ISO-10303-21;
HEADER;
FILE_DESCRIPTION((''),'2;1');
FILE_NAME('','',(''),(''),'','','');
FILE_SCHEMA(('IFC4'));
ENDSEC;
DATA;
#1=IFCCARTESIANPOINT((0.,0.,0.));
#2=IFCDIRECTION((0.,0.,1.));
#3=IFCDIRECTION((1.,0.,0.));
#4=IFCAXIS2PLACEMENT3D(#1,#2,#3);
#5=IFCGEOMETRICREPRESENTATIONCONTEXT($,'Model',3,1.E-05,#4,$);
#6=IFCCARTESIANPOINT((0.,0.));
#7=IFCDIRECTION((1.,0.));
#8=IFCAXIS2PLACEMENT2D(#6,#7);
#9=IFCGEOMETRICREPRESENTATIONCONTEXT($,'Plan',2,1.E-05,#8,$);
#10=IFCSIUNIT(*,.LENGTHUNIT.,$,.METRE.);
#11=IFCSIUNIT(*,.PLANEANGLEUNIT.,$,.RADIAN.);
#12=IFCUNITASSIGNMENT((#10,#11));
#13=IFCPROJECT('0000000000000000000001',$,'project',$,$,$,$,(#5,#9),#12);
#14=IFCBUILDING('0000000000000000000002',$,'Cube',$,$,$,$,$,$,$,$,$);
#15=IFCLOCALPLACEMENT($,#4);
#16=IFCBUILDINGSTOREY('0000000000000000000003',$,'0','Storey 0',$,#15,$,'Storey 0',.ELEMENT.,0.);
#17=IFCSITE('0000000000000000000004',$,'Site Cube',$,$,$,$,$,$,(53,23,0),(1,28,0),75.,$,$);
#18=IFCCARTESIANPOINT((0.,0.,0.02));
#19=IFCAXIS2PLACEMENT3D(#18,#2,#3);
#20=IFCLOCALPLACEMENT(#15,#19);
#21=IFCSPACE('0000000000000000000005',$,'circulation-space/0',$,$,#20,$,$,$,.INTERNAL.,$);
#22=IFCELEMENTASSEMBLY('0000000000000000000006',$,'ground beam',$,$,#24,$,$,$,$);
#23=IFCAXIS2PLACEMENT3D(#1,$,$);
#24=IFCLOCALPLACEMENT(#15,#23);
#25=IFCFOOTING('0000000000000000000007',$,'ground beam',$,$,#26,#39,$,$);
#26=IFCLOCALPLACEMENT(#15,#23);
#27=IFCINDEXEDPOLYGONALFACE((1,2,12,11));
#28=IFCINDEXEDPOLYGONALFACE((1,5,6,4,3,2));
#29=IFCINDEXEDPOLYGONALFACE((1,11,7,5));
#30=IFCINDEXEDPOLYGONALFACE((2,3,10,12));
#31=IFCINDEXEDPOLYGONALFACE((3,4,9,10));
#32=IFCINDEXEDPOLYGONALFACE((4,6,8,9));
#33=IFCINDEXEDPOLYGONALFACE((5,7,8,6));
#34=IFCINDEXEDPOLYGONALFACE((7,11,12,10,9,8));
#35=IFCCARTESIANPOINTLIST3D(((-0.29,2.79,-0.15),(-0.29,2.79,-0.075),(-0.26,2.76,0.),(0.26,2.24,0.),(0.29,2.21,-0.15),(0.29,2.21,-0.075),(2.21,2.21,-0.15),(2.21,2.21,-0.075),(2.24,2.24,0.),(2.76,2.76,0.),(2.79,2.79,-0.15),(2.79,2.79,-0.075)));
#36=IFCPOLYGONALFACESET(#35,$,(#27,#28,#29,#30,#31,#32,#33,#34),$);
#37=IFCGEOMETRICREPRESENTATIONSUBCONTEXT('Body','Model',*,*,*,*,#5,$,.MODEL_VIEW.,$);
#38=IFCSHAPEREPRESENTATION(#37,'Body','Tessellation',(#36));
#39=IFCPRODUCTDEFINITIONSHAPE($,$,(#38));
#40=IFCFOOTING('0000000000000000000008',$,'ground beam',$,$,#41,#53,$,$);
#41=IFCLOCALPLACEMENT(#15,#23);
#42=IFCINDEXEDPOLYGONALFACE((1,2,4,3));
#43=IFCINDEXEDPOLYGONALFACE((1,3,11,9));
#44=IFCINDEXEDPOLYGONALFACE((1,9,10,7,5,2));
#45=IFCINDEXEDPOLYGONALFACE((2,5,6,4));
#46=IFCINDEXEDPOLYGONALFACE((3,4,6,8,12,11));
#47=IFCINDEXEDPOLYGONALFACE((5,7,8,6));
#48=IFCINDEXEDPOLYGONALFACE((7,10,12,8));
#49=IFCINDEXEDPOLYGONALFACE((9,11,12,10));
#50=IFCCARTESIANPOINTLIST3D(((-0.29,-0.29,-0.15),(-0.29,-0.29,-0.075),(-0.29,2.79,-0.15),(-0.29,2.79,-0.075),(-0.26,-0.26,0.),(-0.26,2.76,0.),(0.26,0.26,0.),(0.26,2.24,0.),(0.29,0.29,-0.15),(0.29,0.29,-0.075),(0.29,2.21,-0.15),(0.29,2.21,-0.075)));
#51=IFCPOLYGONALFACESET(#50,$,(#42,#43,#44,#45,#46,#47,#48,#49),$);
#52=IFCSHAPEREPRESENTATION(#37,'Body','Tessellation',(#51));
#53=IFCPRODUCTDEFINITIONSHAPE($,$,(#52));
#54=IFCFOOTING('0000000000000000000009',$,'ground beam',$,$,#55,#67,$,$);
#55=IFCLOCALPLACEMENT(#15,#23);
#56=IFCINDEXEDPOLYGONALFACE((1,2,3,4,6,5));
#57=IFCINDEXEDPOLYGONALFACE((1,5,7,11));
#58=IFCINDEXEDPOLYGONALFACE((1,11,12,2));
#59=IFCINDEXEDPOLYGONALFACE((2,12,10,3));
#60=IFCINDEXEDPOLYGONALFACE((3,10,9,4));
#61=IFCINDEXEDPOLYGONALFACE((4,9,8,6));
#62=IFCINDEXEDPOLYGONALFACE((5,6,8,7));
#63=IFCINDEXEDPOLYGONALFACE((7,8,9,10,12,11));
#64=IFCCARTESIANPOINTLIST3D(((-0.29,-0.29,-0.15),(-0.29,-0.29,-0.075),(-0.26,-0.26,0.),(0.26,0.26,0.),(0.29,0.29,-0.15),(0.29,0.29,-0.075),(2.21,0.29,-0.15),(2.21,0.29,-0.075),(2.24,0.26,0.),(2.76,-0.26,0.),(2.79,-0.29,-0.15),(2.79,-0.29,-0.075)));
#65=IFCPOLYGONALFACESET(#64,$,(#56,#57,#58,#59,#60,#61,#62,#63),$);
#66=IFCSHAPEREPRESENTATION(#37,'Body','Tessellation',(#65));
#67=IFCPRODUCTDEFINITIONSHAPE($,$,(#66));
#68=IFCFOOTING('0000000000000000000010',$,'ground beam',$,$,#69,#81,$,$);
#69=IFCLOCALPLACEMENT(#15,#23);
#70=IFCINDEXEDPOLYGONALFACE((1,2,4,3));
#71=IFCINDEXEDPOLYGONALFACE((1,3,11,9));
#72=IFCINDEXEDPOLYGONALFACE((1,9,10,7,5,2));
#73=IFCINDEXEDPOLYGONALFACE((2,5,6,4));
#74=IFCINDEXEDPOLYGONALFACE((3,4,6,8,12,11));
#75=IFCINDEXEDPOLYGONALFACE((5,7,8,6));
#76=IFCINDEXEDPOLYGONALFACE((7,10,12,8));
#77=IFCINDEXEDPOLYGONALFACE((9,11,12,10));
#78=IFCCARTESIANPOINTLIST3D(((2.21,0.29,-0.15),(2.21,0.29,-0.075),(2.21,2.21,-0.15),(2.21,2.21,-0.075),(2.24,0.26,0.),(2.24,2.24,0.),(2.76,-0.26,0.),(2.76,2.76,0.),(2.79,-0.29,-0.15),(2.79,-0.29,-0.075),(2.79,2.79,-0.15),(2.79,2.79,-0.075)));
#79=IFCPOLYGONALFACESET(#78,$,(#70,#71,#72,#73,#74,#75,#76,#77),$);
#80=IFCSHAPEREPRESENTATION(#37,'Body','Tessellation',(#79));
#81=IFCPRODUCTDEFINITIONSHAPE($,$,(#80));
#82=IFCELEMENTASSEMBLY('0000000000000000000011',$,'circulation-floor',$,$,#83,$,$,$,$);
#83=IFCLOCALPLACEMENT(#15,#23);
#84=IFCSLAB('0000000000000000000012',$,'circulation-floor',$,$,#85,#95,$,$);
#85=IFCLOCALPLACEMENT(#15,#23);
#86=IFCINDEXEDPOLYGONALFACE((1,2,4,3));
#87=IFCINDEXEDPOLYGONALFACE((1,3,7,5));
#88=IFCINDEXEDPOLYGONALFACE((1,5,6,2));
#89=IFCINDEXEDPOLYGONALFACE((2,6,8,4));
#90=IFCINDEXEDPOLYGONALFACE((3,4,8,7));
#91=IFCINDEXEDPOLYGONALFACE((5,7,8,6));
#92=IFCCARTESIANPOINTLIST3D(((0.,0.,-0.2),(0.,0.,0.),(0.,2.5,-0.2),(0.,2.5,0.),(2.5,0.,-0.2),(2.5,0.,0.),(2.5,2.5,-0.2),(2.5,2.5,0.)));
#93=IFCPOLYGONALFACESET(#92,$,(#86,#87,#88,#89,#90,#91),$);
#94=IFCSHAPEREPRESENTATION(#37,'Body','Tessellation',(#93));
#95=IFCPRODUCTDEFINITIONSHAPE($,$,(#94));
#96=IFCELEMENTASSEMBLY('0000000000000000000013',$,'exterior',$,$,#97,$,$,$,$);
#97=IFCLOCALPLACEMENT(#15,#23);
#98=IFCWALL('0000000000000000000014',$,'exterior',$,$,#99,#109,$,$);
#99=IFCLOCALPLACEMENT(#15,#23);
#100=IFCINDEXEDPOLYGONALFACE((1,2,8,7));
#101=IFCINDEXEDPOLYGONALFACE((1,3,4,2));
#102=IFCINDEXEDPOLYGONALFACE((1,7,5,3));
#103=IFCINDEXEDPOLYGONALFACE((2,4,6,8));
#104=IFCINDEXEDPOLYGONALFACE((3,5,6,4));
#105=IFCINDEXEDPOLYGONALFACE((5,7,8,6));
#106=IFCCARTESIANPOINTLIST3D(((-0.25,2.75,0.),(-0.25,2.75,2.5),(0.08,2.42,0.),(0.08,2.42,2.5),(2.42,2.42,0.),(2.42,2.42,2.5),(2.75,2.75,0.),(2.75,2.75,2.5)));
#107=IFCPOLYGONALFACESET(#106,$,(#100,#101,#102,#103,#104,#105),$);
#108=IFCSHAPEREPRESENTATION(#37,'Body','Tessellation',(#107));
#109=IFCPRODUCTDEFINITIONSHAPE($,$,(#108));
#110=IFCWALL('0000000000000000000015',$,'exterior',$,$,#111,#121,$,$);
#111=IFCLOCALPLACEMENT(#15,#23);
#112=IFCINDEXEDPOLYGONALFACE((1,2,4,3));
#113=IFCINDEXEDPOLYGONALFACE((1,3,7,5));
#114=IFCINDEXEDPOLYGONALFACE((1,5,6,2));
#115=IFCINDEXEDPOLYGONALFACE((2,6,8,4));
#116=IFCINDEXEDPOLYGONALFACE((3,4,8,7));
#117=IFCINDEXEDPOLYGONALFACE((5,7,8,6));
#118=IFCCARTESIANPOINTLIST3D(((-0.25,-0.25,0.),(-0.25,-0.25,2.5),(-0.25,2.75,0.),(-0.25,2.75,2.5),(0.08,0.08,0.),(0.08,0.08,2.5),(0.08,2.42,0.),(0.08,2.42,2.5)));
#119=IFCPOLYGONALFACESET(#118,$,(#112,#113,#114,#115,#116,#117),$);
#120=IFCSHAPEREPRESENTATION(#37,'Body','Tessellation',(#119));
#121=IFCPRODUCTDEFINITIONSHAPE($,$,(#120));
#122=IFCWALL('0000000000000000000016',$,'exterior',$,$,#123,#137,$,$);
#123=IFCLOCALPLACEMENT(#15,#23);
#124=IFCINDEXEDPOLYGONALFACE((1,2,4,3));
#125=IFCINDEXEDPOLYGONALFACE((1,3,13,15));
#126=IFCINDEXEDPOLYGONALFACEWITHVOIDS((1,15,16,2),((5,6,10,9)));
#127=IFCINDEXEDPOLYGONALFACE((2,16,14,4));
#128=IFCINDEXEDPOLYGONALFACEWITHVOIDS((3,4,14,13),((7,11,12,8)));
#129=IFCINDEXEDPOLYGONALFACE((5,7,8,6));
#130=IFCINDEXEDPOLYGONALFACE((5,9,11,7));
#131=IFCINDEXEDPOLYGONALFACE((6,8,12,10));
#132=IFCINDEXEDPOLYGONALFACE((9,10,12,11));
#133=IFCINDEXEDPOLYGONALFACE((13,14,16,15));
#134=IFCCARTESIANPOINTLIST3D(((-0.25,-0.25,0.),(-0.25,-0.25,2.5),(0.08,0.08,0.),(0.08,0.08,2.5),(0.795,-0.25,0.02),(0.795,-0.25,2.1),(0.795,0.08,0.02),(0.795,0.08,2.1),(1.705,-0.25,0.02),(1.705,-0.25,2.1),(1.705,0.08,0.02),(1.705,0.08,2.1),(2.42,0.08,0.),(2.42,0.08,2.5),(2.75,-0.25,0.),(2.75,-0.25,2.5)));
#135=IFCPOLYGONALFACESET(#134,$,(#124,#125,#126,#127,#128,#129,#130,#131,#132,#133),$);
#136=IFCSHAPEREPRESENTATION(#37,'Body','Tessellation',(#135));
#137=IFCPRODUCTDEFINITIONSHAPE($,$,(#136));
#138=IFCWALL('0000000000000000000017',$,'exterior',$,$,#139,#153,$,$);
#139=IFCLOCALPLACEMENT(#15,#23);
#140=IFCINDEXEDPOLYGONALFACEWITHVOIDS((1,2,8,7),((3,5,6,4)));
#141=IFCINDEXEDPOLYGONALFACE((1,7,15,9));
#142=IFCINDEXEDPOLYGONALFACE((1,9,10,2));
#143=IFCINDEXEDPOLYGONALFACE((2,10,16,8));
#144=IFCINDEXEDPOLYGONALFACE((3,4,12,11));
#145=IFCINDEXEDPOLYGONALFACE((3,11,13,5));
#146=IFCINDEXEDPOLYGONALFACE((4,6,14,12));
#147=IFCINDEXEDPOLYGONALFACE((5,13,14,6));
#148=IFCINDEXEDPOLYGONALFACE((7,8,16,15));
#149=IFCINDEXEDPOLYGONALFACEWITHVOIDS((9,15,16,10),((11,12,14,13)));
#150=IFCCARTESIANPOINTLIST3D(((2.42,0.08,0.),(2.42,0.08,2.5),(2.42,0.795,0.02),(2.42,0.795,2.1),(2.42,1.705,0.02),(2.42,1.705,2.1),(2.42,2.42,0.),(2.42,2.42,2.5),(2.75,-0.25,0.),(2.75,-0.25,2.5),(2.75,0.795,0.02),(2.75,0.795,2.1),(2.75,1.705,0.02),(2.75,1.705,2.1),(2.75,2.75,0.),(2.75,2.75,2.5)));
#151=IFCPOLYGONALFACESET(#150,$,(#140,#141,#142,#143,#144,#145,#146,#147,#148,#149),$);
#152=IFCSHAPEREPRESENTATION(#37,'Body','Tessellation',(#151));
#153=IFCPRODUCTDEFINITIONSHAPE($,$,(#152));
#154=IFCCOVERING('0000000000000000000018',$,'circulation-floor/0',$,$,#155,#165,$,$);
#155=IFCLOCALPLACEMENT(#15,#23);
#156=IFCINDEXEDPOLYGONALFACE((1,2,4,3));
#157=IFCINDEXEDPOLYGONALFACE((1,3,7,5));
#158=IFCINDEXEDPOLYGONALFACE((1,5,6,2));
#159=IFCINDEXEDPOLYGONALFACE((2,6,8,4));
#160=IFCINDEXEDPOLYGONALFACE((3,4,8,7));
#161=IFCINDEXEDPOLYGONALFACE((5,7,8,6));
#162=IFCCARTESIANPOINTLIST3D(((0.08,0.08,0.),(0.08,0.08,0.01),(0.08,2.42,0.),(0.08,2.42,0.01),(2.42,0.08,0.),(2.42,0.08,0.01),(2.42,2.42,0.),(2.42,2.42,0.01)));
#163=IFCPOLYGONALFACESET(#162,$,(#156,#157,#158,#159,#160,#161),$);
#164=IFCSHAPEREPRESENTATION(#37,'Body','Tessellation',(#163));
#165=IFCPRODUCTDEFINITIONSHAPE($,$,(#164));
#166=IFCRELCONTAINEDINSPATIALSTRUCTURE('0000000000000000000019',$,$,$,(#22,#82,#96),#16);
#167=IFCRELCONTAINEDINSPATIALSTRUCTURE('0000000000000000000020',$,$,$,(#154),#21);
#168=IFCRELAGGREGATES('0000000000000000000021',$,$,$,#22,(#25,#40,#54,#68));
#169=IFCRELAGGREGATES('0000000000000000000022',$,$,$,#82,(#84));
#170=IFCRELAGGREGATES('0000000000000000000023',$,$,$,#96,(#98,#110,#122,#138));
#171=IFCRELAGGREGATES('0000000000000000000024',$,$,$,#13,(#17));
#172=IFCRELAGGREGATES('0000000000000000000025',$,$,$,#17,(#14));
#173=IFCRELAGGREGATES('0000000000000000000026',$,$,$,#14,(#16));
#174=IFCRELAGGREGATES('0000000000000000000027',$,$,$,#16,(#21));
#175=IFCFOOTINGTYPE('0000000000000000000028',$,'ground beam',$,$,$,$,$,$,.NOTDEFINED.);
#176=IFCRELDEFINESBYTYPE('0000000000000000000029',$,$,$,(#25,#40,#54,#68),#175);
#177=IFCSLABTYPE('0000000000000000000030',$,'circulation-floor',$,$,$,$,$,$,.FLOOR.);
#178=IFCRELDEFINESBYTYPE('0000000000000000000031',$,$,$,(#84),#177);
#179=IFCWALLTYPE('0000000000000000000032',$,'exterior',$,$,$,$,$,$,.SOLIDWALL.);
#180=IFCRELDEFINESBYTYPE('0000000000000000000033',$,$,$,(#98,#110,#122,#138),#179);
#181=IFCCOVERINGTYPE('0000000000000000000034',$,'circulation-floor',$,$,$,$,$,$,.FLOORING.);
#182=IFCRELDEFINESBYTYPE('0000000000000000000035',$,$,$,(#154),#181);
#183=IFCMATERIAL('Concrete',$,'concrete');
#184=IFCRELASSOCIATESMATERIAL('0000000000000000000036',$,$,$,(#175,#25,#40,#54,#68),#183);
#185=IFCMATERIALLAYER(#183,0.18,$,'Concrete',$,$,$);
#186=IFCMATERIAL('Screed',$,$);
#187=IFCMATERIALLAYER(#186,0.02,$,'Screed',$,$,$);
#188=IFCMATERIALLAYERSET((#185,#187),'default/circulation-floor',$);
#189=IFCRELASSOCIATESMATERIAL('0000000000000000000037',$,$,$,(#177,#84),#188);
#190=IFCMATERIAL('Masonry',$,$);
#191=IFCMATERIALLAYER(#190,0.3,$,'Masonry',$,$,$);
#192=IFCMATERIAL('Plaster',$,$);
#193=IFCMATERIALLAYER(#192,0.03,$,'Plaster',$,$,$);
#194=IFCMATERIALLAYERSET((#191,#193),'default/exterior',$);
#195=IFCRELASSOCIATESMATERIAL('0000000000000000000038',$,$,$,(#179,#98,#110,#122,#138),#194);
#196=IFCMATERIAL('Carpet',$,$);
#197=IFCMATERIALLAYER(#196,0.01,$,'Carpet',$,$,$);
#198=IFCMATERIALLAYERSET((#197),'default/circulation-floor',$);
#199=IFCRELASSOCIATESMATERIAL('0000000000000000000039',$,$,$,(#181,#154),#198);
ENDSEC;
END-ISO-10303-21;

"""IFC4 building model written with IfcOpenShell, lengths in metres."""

from ifc_helpers import new_model, si_unit, frame, origin, origin_with_axes, origin_2d_with_axis, place, context, subcontext, project, spatial, polyline, outline, extrude, clip, halfspace, material, layer, layer_set, layer_usage, material_profile, profile_set, profile_usage, type_object, element, aggregate, save


model = new_model("IFC4")

# Units and contexts
model_context = context("Model", 3, precision=1e-05, world=origin_with_axes())
plan_context = context("Plan", 2, precision=1e-05, world=origin_2d_with_axis())
body_context = subcontext(model_context, "Body", "Model", "MODEL_VIEW")
ifc_project = project(units=[si_unit("LENGTHUNIT", "METRE"), si_unit("PLANEANGLEUNIT", "RADIAN")], contexts=[model_context, plan_context])

# Site, building, storey
site = spatial("IfcSite", under=ifc_project, Name="Site Cube", RefLatitude=(53, 23, 0), RefLongitude=(1, 28, 0), RefElevation=75.0)
building = spatial("IfcBuilding", under=site, Name="Cube")
storey_placement = place(None, origin_with_axes())
storey = spatial("IfcBuildingStorey", under=building, at=storey_placement, Name="0", Description="Storey 0", LongName="Storey 0", CompositionType="ELEMENT", Elevation=0.0)

# Element assembly, footings
assembly_1_placement = place(storey_placement, origin_with_axes())
assembly_1 = element("IfcElementAssembly", 1, at=assembly_1_placement, inside=storey, Name="ground beam")
ifc_material_1 = material(Name="Concrete", Category="concrete")
ifc_material_profile = material_profile(ifc_material_1, outline(polyline([(-0.26, 0.0), (-0.29, -0.075), (-0.29, -0.15), (0.29, -0.15), (0.29, -0.075), (0.26, 0.0), (-0.26, 0.0)])))
ifc_profile_set = profile_set([ifc_material_profile])
ifc_profile_usage_1 = profile_usage(ifc_profile_set)
footing_type = type_object("IfcFootingType", Name="ground beam", PredefinedType="NOTDEFINED", material=ifc_profile_set)
footing_1_placement = place(assembly_1_placement, frame((-1.0, 2.5, 0.0), z_axis=(1.0, 0.0, 0.0), x_axis=(0.0, 1.0, 0.0)))
footing_1 = element("IfcFooting", 2, at=footing_1_placement, type_object=footing_type, material=ifc_profile_usage_1, Name="ground beam", context=body_context, shape_type="Clipping", body=[
    clip(clip(extrude(outline(polyline([(-0.26, 0.0), (-0.29, -0.075), (-0.29, -0.15), (0.29, -0.15), (0.29, -0.075), (0.26, 0.0), (-0.26, 0.0)])), origin_with_axes(), (0.0, 0.0, 1.0), 4.5), halfspace(frame((0.0, 0.0, 1.0), z_axis=(-0.707107, 0.0, -0.707107), x_axis=(0.707107, 0.0, -0.707107)), False)), halfspace(frame((0.0, 0.0, 3.5), z_axis=(-0.707107, 0.0, 0.707107), x_axis=(0.707107, 0.0, 0.707107)), False)),
])
ifc_profile_usage_2 = profile_usage(ifc_profile_set)
footing_2_placement = place(assembly_1_placement, frame((0.0, -1.0, 0.0), z_axis=(0.0, 1.0, 0.0), x_axis=(-1.0, 0.0, 0.0)))
footing_2 = element("IfcFooting", 3, at=footing_2_placement, type_object=footing_type, material=ifc_profile_usage_2, Name="ground beam", context=body_context, shape_type="Clipping", body=[
    clip(clip(extrude(outline(polyline([(-0.26, 0.0), (-0.29, -0.075), (-0.29, -0.15), (0.29, -0.15), (0.29, -0.075), (0.26, 0.0), (-0.26, 0.0)])), origin_with_axes(), (0.0, 0.0, 1.0), 4.5), halfspace(frame((0.0, 0.0, 1.0), z_axis=(-0.707107, 0.0, -0.707107), x_axis=(0.707107, 0.0, -0.707107)), False)), halfspace(frame((0.0, 0.0, 3.5), z_axis=(-0.707107, 0.0, 0.707107), x_axis=(0.707107, 0.0, 0.707107)), False)),
])
ifc_profile_usage_3 = profile_usage(ifc_profile_set)
footing_3_placement = place(assembly_1_placement, frame((3.5, 0.0, 0.0), z_axis=(-1.0, 0.0, 0.0), x_axis=(0.0, -1.0, 0.0)))
footing_3 = element("IfcFooting", 4, at=footing_3_placement, type_object=footing_type, material=ifc_profile_usage_3, Name="ground beam", context=body_context, shape_type="Clipping", body=[
    clip(clip(extrude(outline(polyline([(-0.26, 0.0), (-0.29, -0.075), (-0.29, -0.15), (0.29, -0.15), (0.29, -0.075), (0.26, 0.0), (-0.26, 0.0)])), origin_with_axes(), (0.0, 0.0, 1.0), 4.5), halfspace(frame((0.0, 0.0, 1.0), z_axis=(-0.707107, 0.0, -0.707107), x_axis=(0.707107, 0.0, -0.707107)), False)), halfspace(frame((0.0, 0.0, 3.5), z_axis=(-0.707107, 0.0, 0.707107), x_axis=(0.707107, 0.0, 0.707107)), False)),
])
ifc_profile_usage_4 = profile_usage(ifc_profile_set)
footing_4_placement = place(assembly_1_placement, frame((2.5, 3.5, 0.0), z_axis=(0.0, -1.0, 0.0), x_axis=(1.0, 0.0, 0.0)))
footing_4 = element("IfcFooting", 5, at=footing_4_placement, type_object=footing_type, material=ifc_profile_usage_4, Name="ground beam", context=body_context, shape_type="Clipping", body=[
    clip(clip(extrude(outline(polyline([(-0.26, 0.0), (-0.29, -0.075), (-0.29, -0.15), (0.29, -0.15), (0.29, -0.075), (0.26, 0.0), (-0.26, 0.0)])), origin_with_axes(), (0.0, 0.0, 1.0), 4.5), halfspace(frame((0.0, 0.0, 1.0), z_axis=(-0.707107, 0.0, -0.707107), x_axis=(0.707107, 0.0, -0.707107)), False)), halfspace(frame((0.0, 0.0, 3.5), z_axis=(-0.707107, 0.0, 0.707107), x_axis=(0.707107, 0.0, 0.707107)), False)),
])
aggregate(assembly_1, [footing_1, footing_2, footing_3, footing_4])

# Element assembly, slab
assembly_2_placement = place(storey_placement, origin_with_axes())
assembly_2 = element("IfcElementAssembly", 6, at=assembly_2_placement, inside=storey, Name="circulation-floor")
ifc_layer_1 = layer(ifc_material_1, 0.18, Name="Concrete")
ifc_material_2 = material(Name="Screed")
ifc_layer_2 = layer(ifc_material_2, 0.02, Name="Screed")
ifc_layer_set_1 = layer_set([ifc_layer_1, ifc_layer_2], Name="default/circulation-floor")
ifc_layer_usage_1 = layer_usage(ifc_layer_set_1, "AXIS3", "POSITIVE", 0.0)
slab_type = type_object("IfcSlabType", Name="circulation-floor", PredefinedType="FLOOR", material=ifc_layer_set_1)
slab_placement = place(assembly_2_placement, frame((0.0, 2.5, -0.2), z_axis=(0.0, 0.0, -1.0), x_axis=(0.0, 1.0, 0.0)))
slab = element("IfcSlab", 7, at=slab_placement, type_object=slab_type, material=ifc_layer_usage_1, Name="circulation-floor", context=body_context, shape_type="SweptSolid", body=[
    extrude(outline(polyline([(0.0, 0.0), (0.0, 2.5), (-2.5, 2.5), (-2.5, 0.0), (0.0, 0.0)])), origin(), (0.0, 0.0, -1.0), 0.2),
])
aggregate(assembly_2, [slab])

# Element assembly, walls, openings
assembly_3_placement = place(storey_placement, frame((2.5, 2.5, 0.0), z_axis=(0.0, 0.0, 1.0), x_axis=(-1.0, 0.0, 0.0)))
assembly_3 = element("IfcElementAssembly", 8, at=assembly_3_placement, inside=storey, Name="exterior")
ifc_material_3 = material(Name="Masonry")
ifc_layer_3 = layer(ifc_material_3, 0.3, Name="Masonry")
ifc_material_4 = material(Name="Plaster")
ifc_layer_4 = layer(ifc_material_4, 0.03, Name="Plaster")
ifc_layer_set_2 = layer_set([ifc_layer_3, ifc_layer_4], Name="default/exterior")
ifc_layer_usage_2 = layer_usage(ifc_layer_set_2, "AXIS2", "POSITIVE", -0.25)
wall_type = type_object("IfcWallType", Name="exterior", PredefinedType="SOLIDWALL", material=ifc_layer_set_2)
wall_1_placement = place(assembly_3_placement, origin_with_axes())
wall_1 = element("IfcWall", 9, at=wall_1_placement, type_object=wall_type, material=ifc_layer_usage_2, Name="exterior", context=body_context, shape_type="SweptSolid", body=[
    extrude(outline(polyline([(0.08, 0.08), (-0.25, -0.25), (2.75, -0.25), (2.42, 0.08), (0.08, 0.08)])), origin(), (0.0, 0.0, 1.0), 2.5),
])
ifc_layer_usage_3 = layer_usage(ifc_layer_set_2, "AXIS2", "POSITIVE", -0.25)
wall_2_placement = place(assembly_3_placement, frame((2.5, 0.0, 0.0), z_axis=(0.0, 0.0, 1.0), x_axis=(0.0, 1.0, 0.0)))
wall_2 = element("IfcWall", 10, at=wall_2_placement, type_object=wall_type, material=ifc_layer_usage_3, Name="exterior", context=body_context, shape_type="SweptSolid", body=[
    extrude(outline(polyline([(0.08, 0.08), (-0.25, -0.25), (2.75, -0.25), (2.42, 0.08), (0.08, 0.08)])), origin(), (0.0, 0.0, 1.0), 2.5),
])
ifc_layer_usage_4 = layer_usage(ifc_layer_set_2, "AXIS2", "POSITIVE", -0.25)
wall_3_placement = place(assembly_3_placement, frame((2.5, 2.5, 0.0), z_axis=(0.0, 0.0, 1.0), x_axis=(-1.0, 0.0, 0.0)))
wall_3 = element("IfcWall", 11, at=wall_3_placement, type_object=wall_type, material=ifc_layer_usage_4, Name="exterior", context=body_context, shape_type="SweptSolid", body=[
    extrude(outline(polyline([(0.08, 0.08), (-0.25, -0.25), (2.75, -0.25), (2.42, 0.08), (0.08, 0.08)])), origin(), (0.0, 0.0, 1.0), 2.5),
])
opening_1_placement = place(wall_3_placement, frame((0.795, -0.25, 0.02), z_axis=(0.0, 0.0, 1.0), x_axis=(1.0, 0.0, 0.0)))
element("IfcOpeningElement", 12, at=opening_1_placement, cuts=wall_3, PredefinedType="OPENING", context=body_context, shape_type="SweptSolid", body=[
    extrude(outline(polyline([(0.0, -0.02), (0.91, -0.02), (0.91, 0.35), (0.0, 0.35), (0.0, -0.02)])), origin(), (0.0, 0.0, 1.0), 2.08),
])
ifc_layer_usage_5 = layer_usage(ifc_layer_set_2, "AXIS2", "POSITIVE", -0.25)
wall_4_placement = place(assembly_3_placement, frame((0.0, 2.5, 0.0), z_axis=(0.0, 0.0, 1.0), x_axis=(0.0, -1.0, 0.0)))
wall_4 = element("IfcWall", 13, at=wall_4_placement, type_object=wall_type, material=ifc_layer_usage_5, Name="exterior", context=body_context, shape_type="SweptSolid", body=[
    extrude(outline(polyline([(0.08, 0.08), (-0.25, -0.25), (2.75, -0.25), (2.42, 0.08), (0.08, 0.08)])), origin(), (0.0, 0.0, 1.0), 2.5),
])
opening_2_placement = place(wall_4_placement, frame((0.795, -0.25, 0.02), z_axis=(0.0, 0.0, 1.0), x_axis=(1.0, 0.0, 0.0)))
element("IfcOpeningElement", 14, at=opening_2_placement, cuts=wall_4, PredefinedType="OPENING", context=body_context, shape_type="SweptSolid", body=[
    extrude(outline(polyline([(0.0, -0.02), (0.91, -0.02), (0.91, 0.35), (0.0, 0.35), (0.0, -0.02)])), origin(), (0.0, 0.0, 1.0), 2.08),
])
aggregate(assembly_3, [wall_1, wall_2, wall_3, wall_4])

# Shared definitions
space_placement = place(storey_placement, frame((0.0, 0.0, 0.02), z_axis=(0.0, 0.0, 1.0), x_axis=(1.0, 0.0, 0.0)))
space = spatial("IfcSpace", under=storey, at=space_placement, Name="circulation-space/0", PredefinedType="INTERNAL")

# Covering
ifc_material_5 = material(Name="Carpet")
ifc_layer_5 = layer(ifc_material_5, 0.01, Name="Carpet")
ifc_layer_set_3 = layer_set([ifc_layer_5], Name="default/circulation-floor")
ifc_layer_usage_6 = layer_usage(ifc_layer_set_3, "AXIS2", "POSITIVE", 0.0)
covering_type = type_object("IfcCoveringType", Name="circulation-floor", PredefinedType="FLOORING", material=ifc_layer_set_3)
covering_placement = place(space_placement, frame((0.0, 0.0, -0.02), z_axis=(0.0, 0.0, 1.0), x_axis=(1.0, 0.0, 0.0)))
element("IfcCovering", 15, at=covering_placement, inside=space, type_object=covering_type, material=ifc_layer_usage_6, Name="circulation-floor/0", context=body_context, shape_type="SweptSolid", body=[
    extrude(outline(polyline([(2.42, 0.08), (2.42, 2.42), (0.08, 2.42), (0.08, 0.08), (2.42, 0.08)])), origin_with_axes(), (0.0, 0.0, 1.0), 0.01),
])

save(model, "model.ifc")
